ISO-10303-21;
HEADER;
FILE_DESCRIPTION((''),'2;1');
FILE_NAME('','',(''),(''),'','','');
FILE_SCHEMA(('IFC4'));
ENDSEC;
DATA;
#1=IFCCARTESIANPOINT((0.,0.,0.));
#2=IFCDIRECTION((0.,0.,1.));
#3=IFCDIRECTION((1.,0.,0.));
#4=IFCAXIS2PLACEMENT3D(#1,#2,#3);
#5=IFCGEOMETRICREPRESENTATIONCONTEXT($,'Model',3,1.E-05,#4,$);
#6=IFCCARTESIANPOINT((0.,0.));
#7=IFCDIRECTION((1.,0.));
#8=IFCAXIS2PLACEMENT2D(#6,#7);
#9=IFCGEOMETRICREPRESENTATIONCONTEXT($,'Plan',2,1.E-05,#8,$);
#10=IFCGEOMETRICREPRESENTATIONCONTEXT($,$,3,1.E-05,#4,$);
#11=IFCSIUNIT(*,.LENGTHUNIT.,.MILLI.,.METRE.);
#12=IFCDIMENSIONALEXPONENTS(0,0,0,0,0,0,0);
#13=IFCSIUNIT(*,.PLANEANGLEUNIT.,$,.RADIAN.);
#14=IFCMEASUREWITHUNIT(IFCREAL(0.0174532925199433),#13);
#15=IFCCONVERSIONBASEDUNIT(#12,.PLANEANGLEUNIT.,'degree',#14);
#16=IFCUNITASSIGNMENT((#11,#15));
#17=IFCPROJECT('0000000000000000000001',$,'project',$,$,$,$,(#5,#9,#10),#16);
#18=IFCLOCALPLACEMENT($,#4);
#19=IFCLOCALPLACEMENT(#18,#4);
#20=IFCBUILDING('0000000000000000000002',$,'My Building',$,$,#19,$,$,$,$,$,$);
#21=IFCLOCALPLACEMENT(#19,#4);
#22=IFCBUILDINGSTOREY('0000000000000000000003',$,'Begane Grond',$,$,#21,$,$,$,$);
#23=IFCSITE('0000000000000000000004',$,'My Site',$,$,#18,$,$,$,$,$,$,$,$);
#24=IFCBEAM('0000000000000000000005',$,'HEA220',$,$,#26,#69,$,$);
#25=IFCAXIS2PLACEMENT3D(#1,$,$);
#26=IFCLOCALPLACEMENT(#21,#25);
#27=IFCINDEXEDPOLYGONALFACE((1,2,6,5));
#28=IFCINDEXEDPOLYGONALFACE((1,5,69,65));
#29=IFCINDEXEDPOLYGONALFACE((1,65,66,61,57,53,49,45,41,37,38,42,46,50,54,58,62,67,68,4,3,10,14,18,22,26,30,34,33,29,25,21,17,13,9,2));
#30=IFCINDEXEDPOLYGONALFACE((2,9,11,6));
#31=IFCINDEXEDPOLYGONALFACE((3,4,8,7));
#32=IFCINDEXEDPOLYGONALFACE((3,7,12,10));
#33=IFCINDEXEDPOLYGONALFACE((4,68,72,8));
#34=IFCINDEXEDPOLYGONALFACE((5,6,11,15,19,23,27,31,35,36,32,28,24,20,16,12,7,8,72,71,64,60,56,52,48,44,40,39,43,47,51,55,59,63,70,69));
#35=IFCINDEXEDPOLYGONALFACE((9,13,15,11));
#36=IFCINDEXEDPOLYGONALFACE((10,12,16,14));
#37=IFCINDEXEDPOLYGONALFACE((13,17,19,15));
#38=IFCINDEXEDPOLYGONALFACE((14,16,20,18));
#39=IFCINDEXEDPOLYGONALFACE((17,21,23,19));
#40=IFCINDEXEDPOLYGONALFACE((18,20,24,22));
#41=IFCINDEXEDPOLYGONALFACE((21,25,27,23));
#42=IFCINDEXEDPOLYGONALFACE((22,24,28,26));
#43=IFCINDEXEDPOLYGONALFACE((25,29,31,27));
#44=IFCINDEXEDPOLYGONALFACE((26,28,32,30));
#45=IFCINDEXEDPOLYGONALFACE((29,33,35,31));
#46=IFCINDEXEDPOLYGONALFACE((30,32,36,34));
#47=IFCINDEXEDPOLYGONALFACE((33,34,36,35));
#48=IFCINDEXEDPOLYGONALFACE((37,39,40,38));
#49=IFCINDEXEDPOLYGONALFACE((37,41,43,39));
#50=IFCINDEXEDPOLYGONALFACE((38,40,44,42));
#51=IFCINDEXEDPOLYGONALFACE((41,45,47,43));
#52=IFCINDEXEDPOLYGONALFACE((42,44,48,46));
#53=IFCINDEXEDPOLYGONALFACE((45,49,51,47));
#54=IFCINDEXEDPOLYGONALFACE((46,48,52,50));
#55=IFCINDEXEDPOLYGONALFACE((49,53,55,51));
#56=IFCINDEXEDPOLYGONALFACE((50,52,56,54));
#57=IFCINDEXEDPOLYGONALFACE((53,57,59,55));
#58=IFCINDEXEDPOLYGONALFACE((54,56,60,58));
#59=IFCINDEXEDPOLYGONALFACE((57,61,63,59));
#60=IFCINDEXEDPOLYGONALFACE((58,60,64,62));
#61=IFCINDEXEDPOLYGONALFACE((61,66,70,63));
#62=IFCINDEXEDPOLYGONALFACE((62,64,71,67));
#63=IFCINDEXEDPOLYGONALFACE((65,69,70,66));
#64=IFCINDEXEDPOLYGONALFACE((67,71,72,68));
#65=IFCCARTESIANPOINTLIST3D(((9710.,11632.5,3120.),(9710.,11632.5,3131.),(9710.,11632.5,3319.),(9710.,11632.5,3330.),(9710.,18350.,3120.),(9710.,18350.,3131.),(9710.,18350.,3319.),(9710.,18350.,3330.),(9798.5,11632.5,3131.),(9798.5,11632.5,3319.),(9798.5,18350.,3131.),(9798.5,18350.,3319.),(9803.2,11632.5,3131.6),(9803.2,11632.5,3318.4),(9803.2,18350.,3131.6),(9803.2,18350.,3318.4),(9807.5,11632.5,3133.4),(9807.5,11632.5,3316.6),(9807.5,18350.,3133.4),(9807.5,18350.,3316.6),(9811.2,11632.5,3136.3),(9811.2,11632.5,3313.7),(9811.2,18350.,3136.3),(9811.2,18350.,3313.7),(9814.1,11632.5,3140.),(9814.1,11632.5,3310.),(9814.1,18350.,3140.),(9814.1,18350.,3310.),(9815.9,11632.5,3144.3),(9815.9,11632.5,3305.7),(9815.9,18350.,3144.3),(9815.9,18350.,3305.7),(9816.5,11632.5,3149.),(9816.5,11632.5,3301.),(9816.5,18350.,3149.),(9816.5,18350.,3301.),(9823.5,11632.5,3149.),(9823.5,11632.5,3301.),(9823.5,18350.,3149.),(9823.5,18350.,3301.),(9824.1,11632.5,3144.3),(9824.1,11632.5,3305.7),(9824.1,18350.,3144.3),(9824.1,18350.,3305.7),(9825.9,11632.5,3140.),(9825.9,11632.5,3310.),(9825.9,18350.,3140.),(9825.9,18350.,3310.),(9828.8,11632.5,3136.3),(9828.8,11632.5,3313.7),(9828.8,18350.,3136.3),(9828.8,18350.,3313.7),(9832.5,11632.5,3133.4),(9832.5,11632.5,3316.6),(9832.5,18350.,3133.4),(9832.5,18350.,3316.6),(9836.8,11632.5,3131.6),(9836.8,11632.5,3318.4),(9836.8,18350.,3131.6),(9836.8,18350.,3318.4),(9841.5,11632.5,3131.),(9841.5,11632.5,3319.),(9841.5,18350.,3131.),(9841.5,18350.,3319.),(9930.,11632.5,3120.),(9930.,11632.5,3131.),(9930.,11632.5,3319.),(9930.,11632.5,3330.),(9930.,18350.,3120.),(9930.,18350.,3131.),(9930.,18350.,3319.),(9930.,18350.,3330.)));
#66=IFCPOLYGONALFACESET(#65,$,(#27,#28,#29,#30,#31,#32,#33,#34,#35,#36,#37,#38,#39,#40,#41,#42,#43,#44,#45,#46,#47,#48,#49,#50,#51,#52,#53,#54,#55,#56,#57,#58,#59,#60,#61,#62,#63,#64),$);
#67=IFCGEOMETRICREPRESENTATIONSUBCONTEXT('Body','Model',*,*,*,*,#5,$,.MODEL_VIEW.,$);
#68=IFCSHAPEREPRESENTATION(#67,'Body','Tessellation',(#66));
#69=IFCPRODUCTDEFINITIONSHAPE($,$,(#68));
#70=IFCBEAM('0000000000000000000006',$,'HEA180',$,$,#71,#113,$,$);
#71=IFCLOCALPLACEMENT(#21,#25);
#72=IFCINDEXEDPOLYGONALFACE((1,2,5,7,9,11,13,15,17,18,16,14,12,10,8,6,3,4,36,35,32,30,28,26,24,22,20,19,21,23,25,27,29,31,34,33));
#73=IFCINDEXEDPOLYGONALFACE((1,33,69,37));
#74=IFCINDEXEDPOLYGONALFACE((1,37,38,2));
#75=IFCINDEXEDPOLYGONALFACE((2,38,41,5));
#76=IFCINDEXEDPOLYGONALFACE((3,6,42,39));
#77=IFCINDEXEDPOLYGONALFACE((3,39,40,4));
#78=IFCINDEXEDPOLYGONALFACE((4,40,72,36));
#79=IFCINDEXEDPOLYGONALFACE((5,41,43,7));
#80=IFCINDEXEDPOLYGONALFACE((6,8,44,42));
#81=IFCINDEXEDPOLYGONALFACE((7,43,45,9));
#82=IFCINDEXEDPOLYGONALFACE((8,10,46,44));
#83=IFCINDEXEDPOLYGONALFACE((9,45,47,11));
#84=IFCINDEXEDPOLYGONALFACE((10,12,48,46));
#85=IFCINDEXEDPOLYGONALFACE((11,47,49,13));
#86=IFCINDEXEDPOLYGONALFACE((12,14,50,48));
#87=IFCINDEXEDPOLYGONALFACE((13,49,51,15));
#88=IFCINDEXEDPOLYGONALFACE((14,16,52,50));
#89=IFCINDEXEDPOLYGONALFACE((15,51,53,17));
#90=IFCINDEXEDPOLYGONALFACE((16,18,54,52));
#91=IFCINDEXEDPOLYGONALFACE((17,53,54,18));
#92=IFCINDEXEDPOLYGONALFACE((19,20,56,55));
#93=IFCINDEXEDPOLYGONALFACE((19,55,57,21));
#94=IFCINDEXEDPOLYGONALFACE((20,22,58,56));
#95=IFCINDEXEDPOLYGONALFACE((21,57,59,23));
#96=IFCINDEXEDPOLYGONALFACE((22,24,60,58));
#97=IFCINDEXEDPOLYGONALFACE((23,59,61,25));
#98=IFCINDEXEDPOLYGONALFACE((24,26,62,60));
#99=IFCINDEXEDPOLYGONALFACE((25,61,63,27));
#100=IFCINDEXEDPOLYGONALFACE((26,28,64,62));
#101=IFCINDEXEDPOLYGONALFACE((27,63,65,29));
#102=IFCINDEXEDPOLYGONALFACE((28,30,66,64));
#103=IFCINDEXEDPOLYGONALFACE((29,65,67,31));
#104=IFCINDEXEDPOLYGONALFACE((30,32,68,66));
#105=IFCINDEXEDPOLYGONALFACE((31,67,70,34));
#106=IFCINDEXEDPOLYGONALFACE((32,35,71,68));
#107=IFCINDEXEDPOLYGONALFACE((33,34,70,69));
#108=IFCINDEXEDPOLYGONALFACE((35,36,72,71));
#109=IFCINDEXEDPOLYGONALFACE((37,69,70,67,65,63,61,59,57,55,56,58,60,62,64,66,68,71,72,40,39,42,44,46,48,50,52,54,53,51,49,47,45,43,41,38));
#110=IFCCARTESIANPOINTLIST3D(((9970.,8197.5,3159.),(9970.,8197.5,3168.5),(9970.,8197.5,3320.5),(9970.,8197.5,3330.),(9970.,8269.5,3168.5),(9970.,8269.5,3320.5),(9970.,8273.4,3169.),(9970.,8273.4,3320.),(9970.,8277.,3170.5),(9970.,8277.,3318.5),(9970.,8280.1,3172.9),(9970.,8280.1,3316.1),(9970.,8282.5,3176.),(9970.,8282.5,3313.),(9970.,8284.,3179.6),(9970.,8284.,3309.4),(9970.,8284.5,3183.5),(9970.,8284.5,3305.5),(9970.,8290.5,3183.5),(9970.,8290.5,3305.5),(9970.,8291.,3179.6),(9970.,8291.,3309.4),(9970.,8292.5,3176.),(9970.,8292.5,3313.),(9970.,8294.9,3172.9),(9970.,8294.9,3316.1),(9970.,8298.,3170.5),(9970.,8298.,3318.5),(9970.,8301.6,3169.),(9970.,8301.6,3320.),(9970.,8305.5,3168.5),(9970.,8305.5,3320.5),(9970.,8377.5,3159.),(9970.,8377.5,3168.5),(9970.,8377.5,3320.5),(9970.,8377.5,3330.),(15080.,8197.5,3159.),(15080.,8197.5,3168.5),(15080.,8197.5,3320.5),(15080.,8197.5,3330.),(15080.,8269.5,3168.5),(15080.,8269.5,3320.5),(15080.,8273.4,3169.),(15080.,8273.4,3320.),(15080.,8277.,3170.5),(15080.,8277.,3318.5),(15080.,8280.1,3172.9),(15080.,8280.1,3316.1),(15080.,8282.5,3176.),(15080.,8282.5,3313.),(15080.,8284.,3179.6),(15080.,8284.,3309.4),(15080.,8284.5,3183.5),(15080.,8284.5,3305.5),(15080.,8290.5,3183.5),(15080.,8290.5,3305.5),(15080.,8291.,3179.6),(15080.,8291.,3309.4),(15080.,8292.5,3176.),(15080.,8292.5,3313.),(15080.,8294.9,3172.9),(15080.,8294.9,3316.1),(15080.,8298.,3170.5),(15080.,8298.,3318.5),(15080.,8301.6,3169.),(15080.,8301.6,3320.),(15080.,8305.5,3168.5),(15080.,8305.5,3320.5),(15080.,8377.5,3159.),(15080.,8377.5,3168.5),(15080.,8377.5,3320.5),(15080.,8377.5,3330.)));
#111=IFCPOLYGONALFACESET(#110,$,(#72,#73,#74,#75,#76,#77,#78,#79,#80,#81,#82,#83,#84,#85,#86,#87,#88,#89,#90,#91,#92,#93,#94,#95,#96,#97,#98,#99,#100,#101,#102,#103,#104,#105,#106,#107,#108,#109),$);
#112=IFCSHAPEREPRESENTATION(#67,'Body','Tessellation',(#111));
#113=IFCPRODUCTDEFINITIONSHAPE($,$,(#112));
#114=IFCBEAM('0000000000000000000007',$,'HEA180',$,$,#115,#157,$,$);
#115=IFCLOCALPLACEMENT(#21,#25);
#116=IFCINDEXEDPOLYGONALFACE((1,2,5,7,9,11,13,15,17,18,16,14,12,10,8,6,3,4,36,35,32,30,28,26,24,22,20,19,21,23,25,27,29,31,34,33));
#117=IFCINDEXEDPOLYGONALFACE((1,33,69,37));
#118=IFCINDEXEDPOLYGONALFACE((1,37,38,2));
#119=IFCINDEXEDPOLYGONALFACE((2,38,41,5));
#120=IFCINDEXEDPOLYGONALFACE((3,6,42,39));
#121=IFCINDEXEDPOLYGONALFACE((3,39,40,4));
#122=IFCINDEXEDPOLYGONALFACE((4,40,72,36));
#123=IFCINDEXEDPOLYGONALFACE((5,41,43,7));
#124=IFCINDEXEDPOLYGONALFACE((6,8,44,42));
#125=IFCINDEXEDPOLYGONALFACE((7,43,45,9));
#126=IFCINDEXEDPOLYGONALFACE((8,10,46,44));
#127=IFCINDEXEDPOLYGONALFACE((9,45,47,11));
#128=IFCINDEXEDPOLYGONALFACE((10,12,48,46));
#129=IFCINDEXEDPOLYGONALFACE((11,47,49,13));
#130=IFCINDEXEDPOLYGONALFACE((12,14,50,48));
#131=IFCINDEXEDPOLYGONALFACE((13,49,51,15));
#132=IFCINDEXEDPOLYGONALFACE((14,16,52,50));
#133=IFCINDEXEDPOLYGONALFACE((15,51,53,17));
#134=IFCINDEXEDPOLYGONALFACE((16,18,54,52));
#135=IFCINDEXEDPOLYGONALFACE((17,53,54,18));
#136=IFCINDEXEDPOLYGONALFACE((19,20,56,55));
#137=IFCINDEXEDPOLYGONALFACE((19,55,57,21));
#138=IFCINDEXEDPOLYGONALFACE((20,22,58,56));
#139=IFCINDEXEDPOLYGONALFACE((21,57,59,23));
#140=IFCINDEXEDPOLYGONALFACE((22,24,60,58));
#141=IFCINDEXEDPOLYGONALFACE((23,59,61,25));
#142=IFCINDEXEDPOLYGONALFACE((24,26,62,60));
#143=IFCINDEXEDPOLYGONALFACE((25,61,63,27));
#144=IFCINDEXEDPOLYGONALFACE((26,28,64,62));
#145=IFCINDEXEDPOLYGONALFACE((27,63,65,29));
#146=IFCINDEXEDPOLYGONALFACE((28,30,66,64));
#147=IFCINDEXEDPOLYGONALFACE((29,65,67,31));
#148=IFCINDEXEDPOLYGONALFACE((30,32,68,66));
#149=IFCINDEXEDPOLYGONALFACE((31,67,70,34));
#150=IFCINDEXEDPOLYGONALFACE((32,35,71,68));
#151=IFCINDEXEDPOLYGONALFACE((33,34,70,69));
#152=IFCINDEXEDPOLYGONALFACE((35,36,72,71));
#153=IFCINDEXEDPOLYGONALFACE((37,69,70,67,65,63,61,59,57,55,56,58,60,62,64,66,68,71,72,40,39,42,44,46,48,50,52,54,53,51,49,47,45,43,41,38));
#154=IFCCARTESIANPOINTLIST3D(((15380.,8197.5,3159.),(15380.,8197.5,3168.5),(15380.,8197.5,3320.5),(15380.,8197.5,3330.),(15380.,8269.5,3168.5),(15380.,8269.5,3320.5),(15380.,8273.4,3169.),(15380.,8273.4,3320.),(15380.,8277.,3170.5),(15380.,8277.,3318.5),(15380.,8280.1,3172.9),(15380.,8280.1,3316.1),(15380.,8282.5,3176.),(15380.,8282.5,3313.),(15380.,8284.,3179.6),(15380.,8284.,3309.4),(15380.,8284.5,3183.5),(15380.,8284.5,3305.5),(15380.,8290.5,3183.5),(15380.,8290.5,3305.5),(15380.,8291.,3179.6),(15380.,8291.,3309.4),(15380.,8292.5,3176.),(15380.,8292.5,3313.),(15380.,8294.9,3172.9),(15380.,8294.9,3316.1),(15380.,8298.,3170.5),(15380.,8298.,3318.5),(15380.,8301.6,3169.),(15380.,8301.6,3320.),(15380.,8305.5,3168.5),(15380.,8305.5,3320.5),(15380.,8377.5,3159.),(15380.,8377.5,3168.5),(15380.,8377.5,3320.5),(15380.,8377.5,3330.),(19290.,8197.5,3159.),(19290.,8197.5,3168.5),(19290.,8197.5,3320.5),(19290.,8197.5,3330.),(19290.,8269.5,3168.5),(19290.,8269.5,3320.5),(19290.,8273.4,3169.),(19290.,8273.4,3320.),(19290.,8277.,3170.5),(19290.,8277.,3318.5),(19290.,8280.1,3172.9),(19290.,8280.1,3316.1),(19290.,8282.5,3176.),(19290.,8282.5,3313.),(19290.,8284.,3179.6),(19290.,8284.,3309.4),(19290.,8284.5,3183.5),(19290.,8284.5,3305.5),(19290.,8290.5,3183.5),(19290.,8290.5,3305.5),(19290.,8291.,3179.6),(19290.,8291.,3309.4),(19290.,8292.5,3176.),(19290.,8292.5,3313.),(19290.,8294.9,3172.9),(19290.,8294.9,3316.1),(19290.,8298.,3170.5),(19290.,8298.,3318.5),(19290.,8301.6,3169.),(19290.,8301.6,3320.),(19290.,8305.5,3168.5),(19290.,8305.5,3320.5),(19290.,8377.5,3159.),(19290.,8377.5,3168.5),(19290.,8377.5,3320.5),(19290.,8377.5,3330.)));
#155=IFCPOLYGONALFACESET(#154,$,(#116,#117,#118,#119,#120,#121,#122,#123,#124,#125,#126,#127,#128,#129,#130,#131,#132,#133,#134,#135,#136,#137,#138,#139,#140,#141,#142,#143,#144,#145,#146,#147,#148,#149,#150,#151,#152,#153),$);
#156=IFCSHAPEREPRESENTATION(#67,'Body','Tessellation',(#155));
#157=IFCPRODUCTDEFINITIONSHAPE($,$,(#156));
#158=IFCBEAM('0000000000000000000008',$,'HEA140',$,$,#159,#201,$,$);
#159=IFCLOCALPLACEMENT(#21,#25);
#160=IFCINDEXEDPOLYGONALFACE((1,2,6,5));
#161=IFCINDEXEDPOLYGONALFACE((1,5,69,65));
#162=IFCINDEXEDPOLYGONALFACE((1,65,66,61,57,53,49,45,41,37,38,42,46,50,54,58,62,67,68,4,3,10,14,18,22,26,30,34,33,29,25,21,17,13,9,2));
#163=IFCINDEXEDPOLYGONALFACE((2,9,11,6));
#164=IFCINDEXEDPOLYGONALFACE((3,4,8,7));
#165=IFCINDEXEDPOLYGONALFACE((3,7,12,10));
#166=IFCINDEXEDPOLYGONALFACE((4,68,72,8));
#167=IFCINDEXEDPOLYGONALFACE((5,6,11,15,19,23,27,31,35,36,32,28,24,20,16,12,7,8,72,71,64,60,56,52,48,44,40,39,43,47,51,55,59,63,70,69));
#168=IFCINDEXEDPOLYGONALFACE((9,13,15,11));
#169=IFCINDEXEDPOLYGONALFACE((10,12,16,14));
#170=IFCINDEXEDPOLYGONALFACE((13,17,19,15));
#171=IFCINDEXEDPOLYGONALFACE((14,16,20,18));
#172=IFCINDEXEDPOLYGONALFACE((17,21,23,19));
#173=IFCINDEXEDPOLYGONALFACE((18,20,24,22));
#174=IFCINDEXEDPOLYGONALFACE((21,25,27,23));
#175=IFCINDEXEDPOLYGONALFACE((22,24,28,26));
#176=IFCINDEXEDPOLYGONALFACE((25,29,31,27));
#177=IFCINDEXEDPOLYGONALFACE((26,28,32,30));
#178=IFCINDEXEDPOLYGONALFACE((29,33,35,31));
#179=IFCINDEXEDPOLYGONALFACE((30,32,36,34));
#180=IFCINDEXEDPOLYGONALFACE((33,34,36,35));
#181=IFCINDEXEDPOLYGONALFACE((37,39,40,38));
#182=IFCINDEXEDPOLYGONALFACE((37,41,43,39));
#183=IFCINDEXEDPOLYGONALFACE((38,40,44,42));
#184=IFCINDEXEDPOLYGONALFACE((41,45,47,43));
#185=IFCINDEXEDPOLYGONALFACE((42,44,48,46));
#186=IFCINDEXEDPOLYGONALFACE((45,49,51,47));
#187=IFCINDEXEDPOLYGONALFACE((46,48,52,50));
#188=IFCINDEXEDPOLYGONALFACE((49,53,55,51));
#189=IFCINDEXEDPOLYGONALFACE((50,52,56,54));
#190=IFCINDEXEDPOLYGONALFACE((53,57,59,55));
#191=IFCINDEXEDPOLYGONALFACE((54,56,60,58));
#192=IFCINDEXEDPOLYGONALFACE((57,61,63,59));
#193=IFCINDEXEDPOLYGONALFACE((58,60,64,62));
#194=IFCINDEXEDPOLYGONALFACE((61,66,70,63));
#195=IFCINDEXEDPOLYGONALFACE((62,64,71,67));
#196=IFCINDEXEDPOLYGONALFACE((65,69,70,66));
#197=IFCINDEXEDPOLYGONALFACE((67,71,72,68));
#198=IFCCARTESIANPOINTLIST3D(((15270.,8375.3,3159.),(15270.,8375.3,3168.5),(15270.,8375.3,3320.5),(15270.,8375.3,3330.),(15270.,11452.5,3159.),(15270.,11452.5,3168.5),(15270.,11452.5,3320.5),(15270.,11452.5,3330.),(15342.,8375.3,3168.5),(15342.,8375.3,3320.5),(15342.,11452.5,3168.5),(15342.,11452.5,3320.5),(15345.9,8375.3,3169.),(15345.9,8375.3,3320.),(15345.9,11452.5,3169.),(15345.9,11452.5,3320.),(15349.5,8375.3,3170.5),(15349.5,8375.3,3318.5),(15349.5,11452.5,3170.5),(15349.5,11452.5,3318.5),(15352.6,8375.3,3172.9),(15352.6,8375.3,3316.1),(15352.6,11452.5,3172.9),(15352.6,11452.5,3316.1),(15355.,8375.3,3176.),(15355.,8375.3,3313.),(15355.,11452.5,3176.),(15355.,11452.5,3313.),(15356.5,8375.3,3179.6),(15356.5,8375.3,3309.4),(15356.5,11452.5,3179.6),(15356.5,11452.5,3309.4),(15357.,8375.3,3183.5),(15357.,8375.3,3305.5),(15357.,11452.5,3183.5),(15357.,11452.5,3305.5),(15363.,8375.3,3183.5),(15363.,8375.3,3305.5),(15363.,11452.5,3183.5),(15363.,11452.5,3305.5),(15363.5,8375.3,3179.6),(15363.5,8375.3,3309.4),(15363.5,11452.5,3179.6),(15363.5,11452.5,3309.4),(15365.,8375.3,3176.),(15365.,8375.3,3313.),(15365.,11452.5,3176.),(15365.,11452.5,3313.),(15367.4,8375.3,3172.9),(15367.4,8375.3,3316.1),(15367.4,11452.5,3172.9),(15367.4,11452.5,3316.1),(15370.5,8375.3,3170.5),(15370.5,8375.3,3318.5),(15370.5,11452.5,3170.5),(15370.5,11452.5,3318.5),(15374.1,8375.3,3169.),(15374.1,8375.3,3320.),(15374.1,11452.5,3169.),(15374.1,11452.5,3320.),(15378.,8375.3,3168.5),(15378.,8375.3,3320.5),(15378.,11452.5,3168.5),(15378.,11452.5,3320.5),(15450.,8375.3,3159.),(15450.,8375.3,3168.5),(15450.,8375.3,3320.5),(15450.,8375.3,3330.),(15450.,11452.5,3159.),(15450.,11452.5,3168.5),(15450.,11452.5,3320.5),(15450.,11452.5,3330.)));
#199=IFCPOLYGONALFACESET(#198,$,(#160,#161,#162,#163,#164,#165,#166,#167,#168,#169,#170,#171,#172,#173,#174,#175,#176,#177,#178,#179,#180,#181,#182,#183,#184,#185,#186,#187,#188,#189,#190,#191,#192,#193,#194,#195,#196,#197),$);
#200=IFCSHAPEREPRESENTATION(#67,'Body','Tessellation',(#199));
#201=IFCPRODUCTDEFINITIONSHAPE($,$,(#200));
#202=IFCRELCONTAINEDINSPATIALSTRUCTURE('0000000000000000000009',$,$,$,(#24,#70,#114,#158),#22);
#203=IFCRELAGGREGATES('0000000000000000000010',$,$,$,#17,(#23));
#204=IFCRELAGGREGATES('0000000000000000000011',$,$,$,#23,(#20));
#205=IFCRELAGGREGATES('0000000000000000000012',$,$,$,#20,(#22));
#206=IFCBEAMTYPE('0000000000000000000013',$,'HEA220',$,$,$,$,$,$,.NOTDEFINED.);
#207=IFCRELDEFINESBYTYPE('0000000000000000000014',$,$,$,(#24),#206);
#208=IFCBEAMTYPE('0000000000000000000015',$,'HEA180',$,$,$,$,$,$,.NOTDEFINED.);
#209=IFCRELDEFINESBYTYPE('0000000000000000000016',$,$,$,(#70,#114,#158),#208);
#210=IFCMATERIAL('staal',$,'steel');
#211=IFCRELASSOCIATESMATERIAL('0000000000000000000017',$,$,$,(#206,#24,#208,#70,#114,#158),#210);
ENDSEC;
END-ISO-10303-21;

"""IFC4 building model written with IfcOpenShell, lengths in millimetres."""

from ifc_helpers import new_model, entity, si_unit, converted_unit, frame, origin_with_axes, origin_2d_with_axis, place, context, subcontext, project, spatial, i_section, extrude, material, material_profile, profile_set, profile_usage, type_object, element, save


model = new_model("IFC4")

# Units and contexts
model_context = context("Model", 3, precision=1e-05, world=origin_with_axes())
plan_context = context("Plan", 2, precision=1e-05, world=origin_2d_with_axis())
context_of_model = context(None, 3, precision=1e-05, world=origin_with_axes())
body_context = subcontext(model_context, "Body", "Model", "MODEL_VIEW")
ifc_project = project(units=[si_unit("LENGTHUNIT", "METRE", prefix="MILLI"), converted_unit("PLANEANGLEUNIT", "degree", entity("IfcReal", 0.0174532925199433), si_unit("PLANEANGLEUNIT", "RADIAN"), dimensions=[0, 0, 0, 0, 0, 0, 0])], contexts=[model_context, plan_context, context_of_model])

# Site, building, storey
site_placement = place(None, origin_with_axes())
site = spatial("IfcSite", under=ifc_project, at=site_placement, Name="My Site")
building_placement = place(site_placement, origin_with_axes())
building = spatial("IfcBuilding", under=site, at=building_placement, Name="My Building")
storey_placement = place(building_placement, origin_with_axes())
storey = spatial("IfcBuildingStorey", under=building, at=storey_placement, Name="Begane Grond")

# Shared definitions
ifc_material = material(Name="staal", Category="steel")

# Beams
ifc_material_profile_1 = material_profile(ifc_material, i_section(OverallWidth=220.0, OverallDepth=210.0, WebThickness=7.0, FlangeThickness=11.0, FilletRadius=18.0))
ifc_profile_set_1 = profile_set([ifc_material_profile_1], Name="HEA220")
ifc_profile_usage_1 = profile_usage(ifc_profile_set_1)
beam_type_1 = type_object("IfcBeamType", Name="HEA220", PredefinedType="NOTDEFINED", material=ifc_profile_set_1)
beam_1_placement = place(storey_placement, frame((9820.0, 18350.0, 3225.0), z_axis=(0.0, -1.0, 0.0), x_axis=(1.0, 0.0, 0.0)))
element("IfcBeam", 1, at=beam_1_placement, inside=storey, type_object=beam_type_1, material=ifc_profile_usage_1, Name="HEA220", context=body_context, shape_type="SweptSolid", body=[
    extrude(i_section(OverallWidth=220.0, OverallDepth=210.0, WebThickness=7.0, FlangeThickness=11.0, FilletRadius=18.0), origin_with_axes(), (0.0, 0.0, 1.0), 6717.5),
])
ifc_material_profile_2 = material_profile(ifc_material, i_section(OverallWidth=180.0, OverallDepth=171.0, WebThickness=6.0, FlangeThickness=9.5, FilletRadius=15.0))
ifc_profile_set_2 = profile_set([ifc_material_profile_2], Name="HEA180")
ifc_profile_usage_2 = profile_usage(ifc_profile_set_2)
beam_type_2 = type_object("IfcBeamType", Name="HEA180", PredefinedType="NOTDEFINED", material=ifc_profile_set_2)
beam_2_placement = place(storey_placement, frame((9970.0, 8287.5, 3244.5), z_axis=(1.0, 0.0, 0.0), x_axis=(0.0, 1.0, 0.0)))
element("IfcBeam", 2, at=beam_2_placement, inside=storey, type_object=beam_type_2, material=ifc_profile_usage_2, Name="HEA180", context=body_context, shape_type="SweptSolid", body=[
    extrude(i_section(OverallWidth=180.0, OverallDepth=171.0, WebThickness=6.0, FlangeThickness=9.5, FilletRadius=15.0), origin_with_axes(), (0.0, 0.0, 1.0), 5110.0),
])
ifc_profile_usage_3 = profile_usage(ifc_profile_set_2)
beam_3_placement = place(storey_placement, frame((15380.0, 8287.5, 3244.5), z_axis=(1.0, 0.0, 0.0), x_axis=(0.0, 1.0, 0.0)))
element("IfcBeam", 3, at=beam_3_placement, inside=storey, type_object=beam_type_2, material=ifc_profile_usage_3, Name="HEA180", context=body_context, shape_type="SweptSolid", body=[
    extrude(i_section(OverallWidth=180.0, OverallDepth=171.0, WebThickness=6.0, FlangeThickness=9.5, FilletRadius=15.0), origin_with_axes(), (0.0, 0.0, 1.0), 3910.0),
])
ifc_profile_usage_4 = profile_usage(ifc_profile_set_2)
beam_4_placement = place(storey_placement, frame((15360.0, 8375.3, 3244.5), z_axis=(0.0, 1.0, 0.0), x_axis=(-1.0, 0.0, 0.0)))
element("IfcBeam", 4, at=beam_4_placement, inside=storey, type_object=beam_type_2, material=ifc_profile_usage_4, Name="HEA140", context=body_context, shape_type="SweptSolid", body=[
    extrude(i_section(OverallWidth=180.0, OverallDepth=171.0, WebThickness=6.0, FlangeThickness=9.5, FilletRadius=15.0), origin_with_axes(), (0.0, 0.0, 1.0), 3077.2),
])

save(model, "model.ifc")
